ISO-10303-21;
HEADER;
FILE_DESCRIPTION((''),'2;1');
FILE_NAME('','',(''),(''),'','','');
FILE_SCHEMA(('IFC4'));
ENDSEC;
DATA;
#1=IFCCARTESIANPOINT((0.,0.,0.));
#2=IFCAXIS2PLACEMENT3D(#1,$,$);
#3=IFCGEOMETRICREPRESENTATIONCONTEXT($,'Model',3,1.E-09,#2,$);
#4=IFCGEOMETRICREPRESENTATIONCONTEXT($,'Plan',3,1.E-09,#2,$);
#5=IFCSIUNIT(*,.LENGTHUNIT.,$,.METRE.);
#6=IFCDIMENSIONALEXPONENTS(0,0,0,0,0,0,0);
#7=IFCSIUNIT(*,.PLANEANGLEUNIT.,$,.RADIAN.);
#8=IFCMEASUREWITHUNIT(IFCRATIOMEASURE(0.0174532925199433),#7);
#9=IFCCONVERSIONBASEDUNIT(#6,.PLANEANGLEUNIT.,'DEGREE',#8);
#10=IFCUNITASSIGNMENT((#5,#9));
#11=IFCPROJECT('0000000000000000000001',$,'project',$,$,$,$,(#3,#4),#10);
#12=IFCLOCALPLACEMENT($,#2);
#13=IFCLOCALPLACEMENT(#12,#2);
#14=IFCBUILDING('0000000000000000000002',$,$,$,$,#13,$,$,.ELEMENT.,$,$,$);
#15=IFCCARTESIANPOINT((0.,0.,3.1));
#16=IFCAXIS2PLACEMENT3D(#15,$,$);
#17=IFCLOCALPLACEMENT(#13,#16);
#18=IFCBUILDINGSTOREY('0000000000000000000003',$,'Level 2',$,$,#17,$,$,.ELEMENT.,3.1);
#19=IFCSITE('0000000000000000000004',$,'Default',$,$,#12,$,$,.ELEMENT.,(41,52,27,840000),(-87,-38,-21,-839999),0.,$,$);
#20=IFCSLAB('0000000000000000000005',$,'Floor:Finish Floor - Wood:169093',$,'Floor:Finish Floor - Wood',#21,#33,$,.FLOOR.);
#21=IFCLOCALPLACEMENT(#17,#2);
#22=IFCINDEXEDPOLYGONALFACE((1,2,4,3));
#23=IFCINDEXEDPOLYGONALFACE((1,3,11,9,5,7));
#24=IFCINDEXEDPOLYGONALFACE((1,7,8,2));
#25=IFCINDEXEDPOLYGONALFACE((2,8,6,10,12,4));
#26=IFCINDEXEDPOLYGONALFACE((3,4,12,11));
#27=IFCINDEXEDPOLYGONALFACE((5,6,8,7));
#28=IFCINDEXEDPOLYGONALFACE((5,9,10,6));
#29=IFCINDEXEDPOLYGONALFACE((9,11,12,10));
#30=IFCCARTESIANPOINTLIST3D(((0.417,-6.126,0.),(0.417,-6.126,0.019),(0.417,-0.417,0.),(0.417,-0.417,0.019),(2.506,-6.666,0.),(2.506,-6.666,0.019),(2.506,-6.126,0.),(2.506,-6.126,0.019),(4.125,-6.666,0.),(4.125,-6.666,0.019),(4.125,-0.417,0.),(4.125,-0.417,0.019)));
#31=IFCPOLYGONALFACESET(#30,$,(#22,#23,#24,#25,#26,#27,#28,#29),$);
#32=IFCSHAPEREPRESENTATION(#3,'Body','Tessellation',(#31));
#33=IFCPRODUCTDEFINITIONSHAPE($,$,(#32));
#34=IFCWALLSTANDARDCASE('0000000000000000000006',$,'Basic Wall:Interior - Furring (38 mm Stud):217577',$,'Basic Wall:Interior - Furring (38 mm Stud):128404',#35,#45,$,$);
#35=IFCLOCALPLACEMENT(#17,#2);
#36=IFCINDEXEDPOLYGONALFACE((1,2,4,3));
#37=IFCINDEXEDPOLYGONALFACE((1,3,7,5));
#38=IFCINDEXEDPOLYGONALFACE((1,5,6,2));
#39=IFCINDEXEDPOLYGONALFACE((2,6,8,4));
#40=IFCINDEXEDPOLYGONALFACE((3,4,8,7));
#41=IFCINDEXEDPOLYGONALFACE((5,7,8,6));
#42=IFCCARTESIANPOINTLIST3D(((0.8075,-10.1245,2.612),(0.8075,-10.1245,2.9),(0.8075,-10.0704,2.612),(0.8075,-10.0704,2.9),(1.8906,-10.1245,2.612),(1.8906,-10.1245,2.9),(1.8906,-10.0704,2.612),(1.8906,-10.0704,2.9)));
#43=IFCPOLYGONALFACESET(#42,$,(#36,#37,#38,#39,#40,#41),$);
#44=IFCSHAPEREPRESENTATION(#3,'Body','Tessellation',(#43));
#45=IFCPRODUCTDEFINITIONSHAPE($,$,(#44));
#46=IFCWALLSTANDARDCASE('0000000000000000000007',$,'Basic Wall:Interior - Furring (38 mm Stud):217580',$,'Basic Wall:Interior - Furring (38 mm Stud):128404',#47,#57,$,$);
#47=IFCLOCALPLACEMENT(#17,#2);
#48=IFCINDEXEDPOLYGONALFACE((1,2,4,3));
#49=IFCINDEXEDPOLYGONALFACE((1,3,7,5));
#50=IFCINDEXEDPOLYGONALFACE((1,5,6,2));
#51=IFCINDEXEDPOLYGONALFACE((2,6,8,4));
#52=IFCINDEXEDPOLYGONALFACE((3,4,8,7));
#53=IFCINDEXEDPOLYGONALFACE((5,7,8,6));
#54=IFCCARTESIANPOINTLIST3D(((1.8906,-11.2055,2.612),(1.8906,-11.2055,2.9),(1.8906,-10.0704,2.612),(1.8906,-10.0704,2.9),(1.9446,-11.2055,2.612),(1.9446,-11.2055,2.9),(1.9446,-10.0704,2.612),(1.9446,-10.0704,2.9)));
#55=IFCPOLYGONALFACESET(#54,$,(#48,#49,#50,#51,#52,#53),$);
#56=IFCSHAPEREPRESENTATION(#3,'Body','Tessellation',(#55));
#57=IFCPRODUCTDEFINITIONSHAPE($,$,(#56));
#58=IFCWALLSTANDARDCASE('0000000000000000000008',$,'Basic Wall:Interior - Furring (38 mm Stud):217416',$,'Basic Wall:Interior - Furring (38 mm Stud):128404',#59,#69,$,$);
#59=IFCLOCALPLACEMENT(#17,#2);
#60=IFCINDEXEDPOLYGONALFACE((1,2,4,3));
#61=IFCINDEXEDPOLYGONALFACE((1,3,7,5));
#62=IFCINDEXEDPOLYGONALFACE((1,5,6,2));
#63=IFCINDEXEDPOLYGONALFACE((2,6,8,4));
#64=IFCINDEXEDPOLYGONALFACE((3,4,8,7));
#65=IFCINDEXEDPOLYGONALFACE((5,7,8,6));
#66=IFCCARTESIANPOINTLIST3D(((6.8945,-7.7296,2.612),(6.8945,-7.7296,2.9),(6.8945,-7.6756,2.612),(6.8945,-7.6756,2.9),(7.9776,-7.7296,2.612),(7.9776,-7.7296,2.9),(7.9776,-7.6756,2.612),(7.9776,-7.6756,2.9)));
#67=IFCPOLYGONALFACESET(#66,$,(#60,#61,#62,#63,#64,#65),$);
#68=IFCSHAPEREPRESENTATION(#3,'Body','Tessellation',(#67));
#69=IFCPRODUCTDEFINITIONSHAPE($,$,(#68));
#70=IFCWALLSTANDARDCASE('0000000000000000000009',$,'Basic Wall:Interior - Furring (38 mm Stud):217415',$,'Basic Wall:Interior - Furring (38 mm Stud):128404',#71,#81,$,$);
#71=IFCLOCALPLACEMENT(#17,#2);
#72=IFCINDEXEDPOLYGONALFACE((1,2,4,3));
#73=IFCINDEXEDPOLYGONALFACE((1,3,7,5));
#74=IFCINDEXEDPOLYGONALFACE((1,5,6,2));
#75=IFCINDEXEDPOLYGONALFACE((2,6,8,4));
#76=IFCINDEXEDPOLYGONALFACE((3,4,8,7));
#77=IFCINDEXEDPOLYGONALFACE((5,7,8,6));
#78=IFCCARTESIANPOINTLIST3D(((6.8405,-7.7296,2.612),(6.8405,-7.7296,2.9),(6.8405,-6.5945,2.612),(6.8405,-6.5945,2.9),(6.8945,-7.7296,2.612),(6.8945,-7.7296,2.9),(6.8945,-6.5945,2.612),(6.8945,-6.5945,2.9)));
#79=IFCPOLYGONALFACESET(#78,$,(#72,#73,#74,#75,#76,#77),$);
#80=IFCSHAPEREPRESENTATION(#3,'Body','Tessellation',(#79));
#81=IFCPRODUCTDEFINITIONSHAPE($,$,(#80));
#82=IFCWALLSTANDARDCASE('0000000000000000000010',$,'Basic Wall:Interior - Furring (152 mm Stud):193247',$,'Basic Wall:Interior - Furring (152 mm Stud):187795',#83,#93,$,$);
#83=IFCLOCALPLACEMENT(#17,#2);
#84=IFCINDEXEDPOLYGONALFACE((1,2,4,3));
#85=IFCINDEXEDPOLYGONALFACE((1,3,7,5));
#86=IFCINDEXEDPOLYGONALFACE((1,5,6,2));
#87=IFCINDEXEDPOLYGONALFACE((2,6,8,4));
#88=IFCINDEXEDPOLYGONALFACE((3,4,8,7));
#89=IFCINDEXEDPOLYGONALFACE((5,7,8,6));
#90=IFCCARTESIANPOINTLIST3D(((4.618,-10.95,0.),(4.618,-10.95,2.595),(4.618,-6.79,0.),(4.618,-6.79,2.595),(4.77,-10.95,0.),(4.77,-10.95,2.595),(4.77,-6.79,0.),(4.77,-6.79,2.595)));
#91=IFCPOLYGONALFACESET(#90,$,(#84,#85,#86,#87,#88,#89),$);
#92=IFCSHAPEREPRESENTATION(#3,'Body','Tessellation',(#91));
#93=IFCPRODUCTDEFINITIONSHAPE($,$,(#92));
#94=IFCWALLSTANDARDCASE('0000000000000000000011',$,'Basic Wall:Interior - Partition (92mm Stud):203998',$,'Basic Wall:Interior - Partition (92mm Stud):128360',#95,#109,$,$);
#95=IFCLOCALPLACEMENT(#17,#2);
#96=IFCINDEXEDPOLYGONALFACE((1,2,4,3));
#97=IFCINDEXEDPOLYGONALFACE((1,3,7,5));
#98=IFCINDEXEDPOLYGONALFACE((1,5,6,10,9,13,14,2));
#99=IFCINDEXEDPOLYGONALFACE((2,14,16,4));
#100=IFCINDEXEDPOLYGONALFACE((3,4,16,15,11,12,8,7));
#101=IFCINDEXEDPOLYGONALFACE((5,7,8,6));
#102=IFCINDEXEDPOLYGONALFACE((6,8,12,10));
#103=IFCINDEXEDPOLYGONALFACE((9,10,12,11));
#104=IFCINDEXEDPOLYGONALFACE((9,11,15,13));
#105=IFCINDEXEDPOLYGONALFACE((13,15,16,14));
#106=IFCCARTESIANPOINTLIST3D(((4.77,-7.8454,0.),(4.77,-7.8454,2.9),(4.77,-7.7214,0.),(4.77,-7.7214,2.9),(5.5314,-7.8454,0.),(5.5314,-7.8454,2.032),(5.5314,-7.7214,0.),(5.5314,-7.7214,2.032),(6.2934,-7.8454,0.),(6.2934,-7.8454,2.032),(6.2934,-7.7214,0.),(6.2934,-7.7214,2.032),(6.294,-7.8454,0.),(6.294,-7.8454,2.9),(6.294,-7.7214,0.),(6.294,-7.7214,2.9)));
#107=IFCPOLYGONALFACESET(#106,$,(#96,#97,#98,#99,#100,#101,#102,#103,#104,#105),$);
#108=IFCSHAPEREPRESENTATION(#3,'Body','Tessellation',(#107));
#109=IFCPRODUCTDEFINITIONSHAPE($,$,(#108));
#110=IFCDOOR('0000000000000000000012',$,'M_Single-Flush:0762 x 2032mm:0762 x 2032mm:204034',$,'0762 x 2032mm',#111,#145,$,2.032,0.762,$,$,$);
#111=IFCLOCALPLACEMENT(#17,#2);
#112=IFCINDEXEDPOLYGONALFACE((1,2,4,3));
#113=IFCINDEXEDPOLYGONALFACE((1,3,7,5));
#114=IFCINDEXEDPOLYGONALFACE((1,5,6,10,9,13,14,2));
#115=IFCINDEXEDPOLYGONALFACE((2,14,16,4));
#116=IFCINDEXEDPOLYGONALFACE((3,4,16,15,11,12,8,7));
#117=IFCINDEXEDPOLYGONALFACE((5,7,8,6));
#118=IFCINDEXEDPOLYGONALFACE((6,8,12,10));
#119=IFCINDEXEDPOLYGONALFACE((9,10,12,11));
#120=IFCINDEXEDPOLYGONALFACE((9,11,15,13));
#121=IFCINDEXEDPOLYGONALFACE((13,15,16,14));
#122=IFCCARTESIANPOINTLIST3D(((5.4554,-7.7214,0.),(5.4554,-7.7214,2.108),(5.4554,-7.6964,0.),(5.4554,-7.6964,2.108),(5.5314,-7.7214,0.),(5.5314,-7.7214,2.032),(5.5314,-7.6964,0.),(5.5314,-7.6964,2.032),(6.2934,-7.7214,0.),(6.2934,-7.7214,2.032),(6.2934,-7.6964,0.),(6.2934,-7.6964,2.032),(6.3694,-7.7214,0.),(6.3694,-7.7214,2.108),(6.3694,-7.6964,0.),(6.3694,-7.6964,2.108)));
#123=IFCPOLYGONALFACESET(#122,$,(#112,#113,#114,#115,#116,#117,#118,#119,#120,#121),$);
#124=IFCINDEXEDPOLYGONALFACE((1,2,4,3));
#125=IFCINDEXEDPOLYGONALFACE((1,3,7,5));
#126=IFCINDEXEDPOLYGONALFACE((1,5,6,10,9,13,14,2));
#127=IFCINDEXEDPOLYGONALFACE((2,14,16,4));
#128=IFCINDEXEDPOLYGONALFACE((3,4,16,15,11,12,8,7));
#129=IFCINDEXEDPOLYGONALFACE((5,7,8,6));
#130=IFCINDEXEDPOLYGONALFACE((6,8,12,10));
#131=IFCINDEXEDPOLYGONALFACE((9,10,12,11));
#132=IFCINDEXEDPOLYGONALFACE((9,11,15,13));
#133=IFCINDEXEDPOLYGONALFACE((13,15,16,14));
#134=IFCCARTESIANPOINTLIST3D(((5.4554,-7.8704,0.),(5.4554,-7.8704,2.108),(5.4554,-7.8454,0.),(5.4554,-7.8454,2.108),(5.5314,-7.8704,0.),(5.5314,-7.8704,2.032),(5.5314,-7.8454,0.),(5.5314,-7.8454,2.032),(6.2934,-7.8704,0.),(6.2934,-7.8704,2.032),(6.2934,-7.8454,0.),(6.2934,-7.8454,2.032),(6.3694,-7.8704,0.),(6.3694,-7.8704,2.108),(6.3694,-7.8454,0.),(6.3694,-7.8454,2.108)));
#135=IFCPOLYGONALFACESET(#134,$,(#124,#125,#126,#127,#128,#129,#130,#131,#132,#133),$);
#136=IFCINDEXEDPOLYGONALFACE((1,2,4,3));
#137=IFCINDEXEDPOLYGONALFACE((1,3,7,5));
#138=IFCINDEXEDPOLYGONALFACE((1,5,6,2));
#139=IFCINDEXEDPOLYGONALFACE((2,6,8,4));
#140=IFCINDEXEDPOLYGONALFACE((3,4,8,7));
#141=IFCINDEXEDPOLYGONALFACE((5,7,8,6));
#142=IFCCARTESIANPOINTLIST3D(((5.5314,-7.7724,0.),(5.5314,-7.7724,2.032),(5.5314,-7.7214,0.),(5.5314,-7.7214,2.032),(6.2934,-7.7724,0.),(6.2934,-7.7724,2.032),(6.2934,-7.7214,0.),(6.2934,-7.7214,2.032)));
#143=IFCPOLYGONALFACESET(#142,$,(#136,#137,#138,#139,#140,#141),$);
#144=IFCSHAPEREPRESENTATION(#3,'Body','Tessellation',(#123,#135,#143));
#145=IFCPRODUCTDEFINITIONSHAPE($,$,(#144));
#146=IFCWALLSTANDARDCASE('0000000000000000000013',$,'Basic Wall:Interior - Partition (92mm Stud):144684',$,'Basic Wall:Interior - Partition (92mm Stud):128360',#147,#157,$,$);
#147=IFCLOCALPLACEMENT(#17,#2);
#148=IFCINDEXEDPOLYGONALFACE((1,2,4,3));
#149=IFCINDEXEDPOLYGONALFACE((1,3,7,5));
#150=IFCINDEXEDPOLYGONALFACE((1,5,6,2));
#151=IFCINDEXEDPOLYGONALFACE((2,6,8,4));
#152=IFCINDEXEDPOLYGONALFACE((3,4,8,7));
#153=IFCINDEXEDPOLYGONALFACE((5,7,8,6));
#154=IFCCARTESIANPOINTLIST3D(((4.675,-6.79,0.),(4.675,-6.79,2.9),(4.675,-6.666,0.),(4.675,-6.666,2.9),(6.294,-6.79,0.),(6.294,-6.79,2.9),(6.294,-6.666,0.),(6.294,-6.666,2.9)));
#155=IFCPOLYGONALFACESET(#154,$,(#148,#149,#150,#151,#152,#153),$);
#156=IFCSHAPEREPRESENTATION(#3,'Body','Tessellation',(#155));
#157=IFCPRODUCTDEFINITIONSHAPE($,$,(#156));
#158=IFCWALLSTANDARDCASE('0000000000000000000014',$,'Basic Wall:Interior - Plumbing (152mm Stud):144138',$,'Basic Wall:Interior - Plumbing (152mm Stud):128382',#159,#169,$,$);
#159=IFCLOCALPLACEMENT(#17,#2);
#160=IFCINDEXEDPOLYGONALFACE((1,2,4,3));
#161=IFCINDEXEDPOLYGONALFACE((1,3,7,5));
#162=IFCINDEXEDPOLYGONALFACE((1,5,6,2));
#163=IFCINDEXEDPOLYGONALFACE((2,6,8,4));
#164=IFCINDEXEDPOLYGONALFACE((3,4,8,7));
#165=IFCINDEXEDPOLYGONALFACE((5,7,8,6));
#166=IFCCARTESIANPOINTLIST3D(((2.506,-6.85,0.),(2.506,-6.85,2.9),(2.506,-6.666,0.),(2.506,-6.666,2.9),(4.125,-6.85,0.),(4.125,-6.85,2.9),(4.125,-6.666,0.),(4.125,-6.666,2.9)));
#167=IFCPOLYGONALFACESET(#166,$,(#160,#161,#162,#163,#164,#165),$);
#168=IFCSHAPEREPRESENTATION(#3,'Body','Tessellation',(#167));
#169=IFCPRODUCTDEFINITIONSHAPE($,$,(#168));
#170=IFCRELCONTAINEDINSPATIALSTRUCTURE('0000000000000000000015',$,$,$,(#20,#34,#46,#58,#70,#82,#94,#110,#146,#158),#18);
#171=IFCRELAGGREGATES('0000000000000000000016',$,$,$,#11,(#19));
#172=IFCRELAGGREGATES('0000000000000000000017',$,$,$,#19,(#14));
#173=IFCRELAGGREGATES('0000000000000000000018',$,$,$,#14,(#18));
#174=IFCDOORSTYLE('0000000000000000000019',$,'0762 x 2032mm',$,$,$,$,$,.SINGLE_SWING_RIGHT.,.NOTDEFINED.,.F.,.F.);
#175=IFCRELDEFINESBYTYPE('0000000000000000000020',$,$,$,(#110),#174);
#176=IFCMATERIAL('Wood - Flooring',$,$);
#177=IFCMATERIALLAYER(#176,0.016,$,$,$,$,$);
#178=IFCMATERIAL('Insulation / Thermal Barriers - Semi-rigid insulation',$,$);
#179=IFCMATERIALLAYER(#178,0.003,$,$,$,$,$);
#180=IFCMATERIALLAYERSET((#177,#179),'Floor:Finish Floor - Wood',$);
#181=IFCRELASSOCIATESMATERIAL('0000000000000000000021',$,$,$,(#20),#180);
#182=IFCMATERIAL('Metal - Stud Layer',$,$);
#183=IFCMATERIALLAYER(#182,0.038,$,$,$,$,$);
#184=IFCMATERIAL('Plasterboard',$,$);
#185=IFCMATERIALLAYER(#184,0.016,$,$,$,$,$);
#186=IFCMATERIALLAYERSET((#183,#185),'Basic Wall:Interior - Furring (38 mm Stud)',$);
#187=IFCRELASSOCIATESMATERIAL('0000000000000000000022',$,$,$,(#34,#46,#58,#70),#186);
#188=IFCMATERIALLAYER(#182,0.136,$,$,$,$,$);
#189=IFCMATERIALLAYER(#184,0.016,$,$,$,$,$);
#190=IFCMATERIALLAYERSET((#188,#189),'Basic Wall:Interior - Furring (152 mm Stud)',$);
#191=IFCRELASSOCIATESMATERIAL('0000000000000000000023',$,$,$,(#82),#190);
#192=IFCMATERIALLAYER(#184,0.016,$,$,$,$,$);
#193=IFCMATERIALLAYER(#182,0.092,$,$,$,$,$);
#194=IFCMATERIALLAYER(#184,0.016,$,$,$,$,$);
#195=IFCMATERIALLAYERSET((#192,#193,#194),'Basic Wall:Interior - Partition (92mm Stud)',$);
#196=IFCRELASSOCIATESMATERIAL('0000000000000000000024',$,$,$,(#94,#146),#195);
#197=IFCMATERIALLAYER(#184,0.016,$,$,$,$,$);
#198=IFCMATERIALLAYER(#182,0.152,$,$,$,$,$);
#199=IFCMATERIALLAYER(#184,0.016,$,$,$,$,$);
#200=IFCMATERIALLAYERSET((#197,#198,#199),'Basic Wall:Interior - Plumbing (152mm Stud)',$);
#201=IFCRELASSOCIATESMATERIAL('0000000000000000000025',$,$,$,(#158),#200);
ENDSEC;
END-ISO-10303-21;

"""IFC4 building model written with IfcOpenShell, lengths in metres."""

from ifc_helpers import new_model, entity, si_unit, converted_unit, frame, frame_2d, origin, origin_2d_with_axis, place, context, project, spatial, polyline, rectangle, outline, extrude, source, transform, mapped, material, layer, layer_set, layer_usage, type_object, type_shapes, element, fill, save


model = new_model("IFC4")

# Units and contexts
model_context = context("Model", 3, precision=1e-09, world=origin())
plan_context = context("Plan", 3, precision=1e-09, world=origin())
ifc_project = project(units=[si_unit("LENGTHUNIT", "METRE"), converted_unit("PLANEANGLEUNIT", "DEGREE", entity("IfcRatioMeasure", 0.0174532925199433), si_unit("PLANEANGLEUNIT", "RADIAN"), dimensions=[0, 0, 0, 0, 0, 0, 0])], contexts=[model_context, plan_context])

# Site, building, storey
site_placement = place(None, origin())
site = spatial("IfcSite", under=ifc_project, at=site_placement, Name="Default", CompositionType="ELEMENT", RefLatitude=(41, 52, 27, 840000), RefLongitude=(-87, -38, -21, -839999), RefElevation=0.0)
building_placement = place(site_placement, origin())
building = spatial("IfcBuilding", under=site, at=building_placement, CompositionType="ELEMENT")
storey_placement = place(building_placement, frame((0.0, 0.0, 3.1)))
storey = spatial("IfcBuildingStorey", under=building, at=storey_placement, Name="Level 2", CompositionType="ELEMENT", Elevation=3.1)

# Slab
ifc_material_1 = material(Name="Wood - Flooring")
ifc_layer_1 = layer(ifc_material_1, 0.016)
ifc_material_2 = material(Name="Insulation / Thermal Barriers - Semi-rigid insulation")
ifc_layer_2 = layer(ifc_material_2, 0.003)
ifc_layer_set_1 = layer_set([ifc_layer_1, ifc_layer_2], Name="Floor:Finish Floor - Wood")
ifc_layer_usage_1 = layer_usage(ifc_layer_set_1, "AXIS3", "POSITIVE", 0.0)
slab_placement = place(storey_placement, frame((0.417, -6.666, 0.0)))
element("IfcSlab", 1, at=slab_placement, inside=storey, material=ifc_layer_usage_1, Name="Floor:Finish Floor - Wood:169093", ObjectType="Floor:Finish Floor - Wood", PredefinedType="FLOOR", context=model_context, shape_type="SweptSolid", body=[
    extrude(outline(polyline([(1.854, 3.1245), (-1.854, 3.1245), (-1.854, -3.1245), (-0.235, -3.1245), (-0.235, -2.5845), (1.854, -2.5845), (1.854, 3.1245)])), frame((1.854, 3.1245, 0.019), z_axis=(0.0, 0.0, -1.0), x_axis=(-1.0, 0.0, 0.0)), (0.0, 0.0, 1.0), 0.019),
])

# Walls
ifc_material_3 = material(Name="Metal - Stud Layer")
ifc_layer_3 = layer(ifc_material_3, 0.038)
ifc_material_4 = material(Name="Plasterboard")
ifc_layer_4 = layer(ifc_material_4, 0.016)
ifc_layer_set_2 = layer_set([ifc_layer_3, ifc_layer_4], Name="Basic Wall:Interior - Furring (38 mm Stud)")
ifc_layer_usage_2 = layer_usage(ifc_layer_set_2, "AXIS2", "NEGATIVE", 0.027)
wall_1_placement = place(storey_placement, frame((0.8075, -10.0975, 2.612)))
element("IfcWallStandardCase", 2, at=wall_1_placement, inside=storey, material=ifc_layer_usage_2, Name="Basic Wall:Interior - Furring (38 mm Stud):217577", ObjectType="Basic Wall:Interior - Furring (38 mm Stud):128404", context=model_context, shape_type="SweptSolid", body=[
    extrude(rectangle(XDim=1.0831, YDim=0.054, at=frame_2d((0.5415, 0.0), x_axis=(-1.0, 0.0))), origin(), (0.0, 0.0, 1.0), 0.288),
])
ifc_layer_usage_3 = layer_usage(ifc_layer_set_2, "AXIS2", "NEGATIVE", 0.027)
wall_2_placement = place(storey_placement, frame((1.9176, -10.0704, 2.612), z_axis=(0.0, 0.0, 1.0), x_axis=(0.0, -1.0, 0.0)))
element("IfcWallStandardCase", 3, at=wall_2_placement, inside=storey, material=ifc_layer_usage_3, Name="Basic Wall:Interior - Furring (38 mm Stud):217580", ObjectType="Basic Wall:Interior - Furring (38 mm Stud):128404", context=model_context, shape_type="SweptSolid", body=[
    extrude(rectangle(XDim=1.1351, YDim=0.054, at=frame_2d((0.5675, 0.0), x_axis=(-1.0, 0.0))), origin(), (0.0, 0.0, 1.0), 0.288),
])
ifc_layer_usage_4 = layer_usage(ifc_layer_set_2, "AXIS2", "NEGATIVE", 0.027)
wall_3_placement = place(storey_placement, frame((7.9776, -7.7026, 2.612), z_axis=(0.0, 0.0, 1.0), x_axis=(-1.0, 0.0, 0.0)))
element("IfcWallStandardCase", 4, at=wall_3_placement, inside=storey, material=ifc_layer_usage_4, Name="Basic Wall:Interior - Furring (38 mm Stud):217416", ObjectType="Basic Wall:Interior - Furring (38 mm Stud):128404", context=model_context, shape_type="SweptSolid", body=[
    extrude(rectangle(XDim=1.0831, YDim=0.054, at=frame_2d((0.5415, 0.0), x_axis=(-1.0, 0.0))), origin(), (0.0, 0.0, 1.0), 0.288),
])
ifc_layer_usage_5 = layer_usage(ifc_layer_set_2, "AXIS2", "NEGATIVE", 0.027)
wall_4_placement = place(storey_placement, frame((6.8675, -7.7296, 2.612), z_axis=(0.0, 0.0, 1.0), x_axis=(0.0, 1.0, 0.0)))
element("IfcWallStandardCase", 5, at=wall_4_placement, inside=storey, material=ifc_layer_usage_5, Name="Basic Wall:Interior - Furring (38 mm Stud):217415", ObjectType="Basic Wall:Interior - Furring (38 mm Stud):128404", context=model_context, shape_type="SweptSolid", body=[
    extrude(rectangle(XDim=1.1351, YDim=0.054, at=frame_2d((0.5675, 0.0), x_axis=(-1.0, 0.0))), origin(), (0.0, 0.0, 1.0), 0.288),
])
ifc_layer_5 = layer(ifc_material_3, 0.136)
ifc_layer_6 = layer(ifc_material_4, 0.016)
ifc_layer_set_3 = layer_set([ifc_layer_5, ifc_layer_6], Name="Basic Wall:Interior - Furring (152 mm Stud)")
ifc_layer_usage_6 = layer_usage(ifc_layer_set_3, "AXIS2", "POSITIVE", -0.076)
wall_5_placement = place(storey_placement, frame((4.694, -6.79, 0.0), z_axis=(0.0, 0.0, 1.0), x_axis=(0.0, -1.0, 0.0)))
element("IfcWallStandardCase", 6, at=wall_5_placement, inside=storey, material=ifc_layer_usage_6, Name="Basic Wall:Interior - Furring (152 mm Stud):193247", ObjectType="Basic Wall:Interior - Furring (152 mm Stud):187795", context=model_context, shape_type="SweptSolid", body=[
    extrude(rectangle(XDim=4.16, YDim=0.152, at=frame_2d((2.08, 0.0), x_axis=(-1.0, 0.0))), origin(), (0.0, 0.0, 1.0), 2.595),
])

# Wall, opening, door
ifc_layer_7 = layer(ifc_material_4, 0.016)
ifc_layer_8 = layer(ifc_material_3, 0.092)
ifc_layer_9 = layer(ifc_material_4, 0.016)
ifc_layer_set_4 = layer_set([ifc_layer_7, ifc_layer_8, ifc_layer_9], Name="Basic Wall:Interior - Partition (92mm Stud)")
ifc_layer_usage_7 = layer_usage(ifc_layer_set_4, "AXIS2", "POSITIVE", -0.062)
wall_6_placement = place(storey_placement, frame((4.77, -7.7834, 0.0)))
wall_6 = element("IfcWallStandardCase", 7, at=wall_6_placement, inside=storey, material=ifc_layer_usage_7, Name="Basic Wall:Interior - Partition (92mm Stud):203998", ObjectType="Basic Wall:Interior - Partition (92mm Stud):128360", context=model_context, shape_type="SweptSolid", body=[
    extrude(rectangle(XDim=1.524, YDim=0.124, at=frame_2d((0.762, 0.0), x_axis=(-1.0, 0.0))), origin(), (0.0, 0.0, 1.0), 2.9),
])
opening_1_placement = place(wall_6_placement, frame((0.7614, -0.062, 0.0)))
opening_1 = element("IfcOpeningElement", 8, at=opening_1_placement, cuts=wall_6, ObjectType="Opening", context=model_context, shape_type="SweptSolid", body=[
    extrude(rectangle(XDim=0.762, YDim=2.032, at=frame_2d((1.016, 0.381), x_axis=(0.0, 1.0))), frame((0.0, 0.0, 0.0), z_axis=(0.0, 1.0, 0.0), x_axis=(0.0, 0.0, 1.0)), (0.0, 0.0, 1.0), 0.124),
])
door_style = type_object("IfcDoorStyle", Name="0762 x 2032mm", ConstructionType="NOTDEFINED", OperationType="SINGLE_SWING_RIGHT", ParameterTakesPrecedence=False, Sizeable=False)
shared_shape = source(origin(), model_context, "Body", "SweptSolid", [
    extrude(outline(polyline([(-0.457, -1.073), (0.457, -1.073), (0.457, 1.035), (0.381, 1.035), (0.381, -0.997), (-0.381, -0.997), (-0.381, 1.035), (-0.457, 1.035), (-0.457, -1.073)])), frame((0.381, 0.124, 1.035), z_axis=(0.0, 1.0, 0.0), x_axis=(1.0, 0.0, 0.0)), (0.0, 0.0, 1.0), 0.025),
    extrude(outline(polyline([(-1.073, -0.457), (1.035, -0.457), (1.035, -0.381), (-0.997, -0.381), (-0.997, 0.381), (1.035, 0.381), (1.035, 0.457), (-1.073, 0.457), (-1.073, -0.457)])), frame((0.381, -0.025, 1.035), z_axis=(0.0, 1.0, 0.0), x_axis=(0.0, 0.0, -1.0)), (0.0, 0.0, 1.0), 0.025),
    extrude(rectangle(XDim=0.051, YDim=0.762, at=origin_2d_with_axis()), frame((0.381, 0.0985, 0.0), z_axis=(0.0, 0.0, 1.0), x_axis=(0.0, 1.0, 0.0)), (0.0, 0.0, 1.0), 2.032),
])
type_shapes(door_style, [shared_shape])
door_1_placement = place(opening_1_placement, origin())
door_1 = element("IfcDoor", 9, at=door_1_placement, inside=storey, type_object=door_style, Name="M_Single-Flush:0762 x 2032mm:0762 x 2032mm:204034", ObjectType="0762 x 2032mm", OverallHeight=2.032, OverallWidth=0.762, context=model_context, shape_type="MappedRepresentation", body=[
    mapped(shared_shape, transform((0.0, 0.0, 0.0), scale=1.0)),
])
fill(opening_1, door_1)

# Walls
ifc_layer_usage_8 = layer_usage(ifc_layer_set_4, "AXIS2", "NEGATIVE", 0.062)
wall_7_placement = place(storey_placement, frame((4.675, -6.728, 0.0)))
element("IfcWallStandardCase", 10, at=wall_7_placement, inside=storey, material=ifc_layer_usage_8, Name="Basic Wall:Interior - Partition (92mm Stud):144684", ObjectType="Basic Wall:Interior - Partition (92mm Stud):128360", context=model_context, shape_type="SweptSolid", body=[
    extrude(rectangle(XDim=1.619, YDim=0.124, at=frame_2d((0.8095, 0.0), x_axis=(-1.0, 0.0))), origin(), (0.0, 0.0, 1.0), 2.9),
])
ifc_layer_10 = layer(ifc_material_4, 0.016)
ifc_layer_11 = layer(ifc_material_3, 0.152)
ifc_layer_12 = layer(ifc_material_4, 0.016)
ifc_layer_set_5 = layer_set([ifc_layer_10, ifc_layer_11, ifc_layer_12], Name="Basic Wall:Interior - Plumbing (152mm Stud)")
ifc_layer_usage_9 = layer_usage(ifc_layer_set_5, "AXIS2", "NEGATIVE", 0.092)
wall_8_placement = place(storey_placement, frame((2.506, -6.758, 0.0)))
element("IfcWallStandardCase", 11, at=wall_8_placement, inside=storey, material=ifc_layer_usage_9, Name="Basic Wall:Interior - Plumbing (152mm Stud):144138", ObjectType="Basic Wall:Interior - Plumbing (152mm Stud):128382", context=model_context, shape_type="SweptSolid", body=[
    extrude(rectangle(XDim=1.619, YDim=0.184, at=frame_2d((0.8095, 0.0), x_axis=(-1.0, 0.0))), origin(), (0.0, 0.0, 1.0), 2.9),
])

save(model, "model.ifc")
